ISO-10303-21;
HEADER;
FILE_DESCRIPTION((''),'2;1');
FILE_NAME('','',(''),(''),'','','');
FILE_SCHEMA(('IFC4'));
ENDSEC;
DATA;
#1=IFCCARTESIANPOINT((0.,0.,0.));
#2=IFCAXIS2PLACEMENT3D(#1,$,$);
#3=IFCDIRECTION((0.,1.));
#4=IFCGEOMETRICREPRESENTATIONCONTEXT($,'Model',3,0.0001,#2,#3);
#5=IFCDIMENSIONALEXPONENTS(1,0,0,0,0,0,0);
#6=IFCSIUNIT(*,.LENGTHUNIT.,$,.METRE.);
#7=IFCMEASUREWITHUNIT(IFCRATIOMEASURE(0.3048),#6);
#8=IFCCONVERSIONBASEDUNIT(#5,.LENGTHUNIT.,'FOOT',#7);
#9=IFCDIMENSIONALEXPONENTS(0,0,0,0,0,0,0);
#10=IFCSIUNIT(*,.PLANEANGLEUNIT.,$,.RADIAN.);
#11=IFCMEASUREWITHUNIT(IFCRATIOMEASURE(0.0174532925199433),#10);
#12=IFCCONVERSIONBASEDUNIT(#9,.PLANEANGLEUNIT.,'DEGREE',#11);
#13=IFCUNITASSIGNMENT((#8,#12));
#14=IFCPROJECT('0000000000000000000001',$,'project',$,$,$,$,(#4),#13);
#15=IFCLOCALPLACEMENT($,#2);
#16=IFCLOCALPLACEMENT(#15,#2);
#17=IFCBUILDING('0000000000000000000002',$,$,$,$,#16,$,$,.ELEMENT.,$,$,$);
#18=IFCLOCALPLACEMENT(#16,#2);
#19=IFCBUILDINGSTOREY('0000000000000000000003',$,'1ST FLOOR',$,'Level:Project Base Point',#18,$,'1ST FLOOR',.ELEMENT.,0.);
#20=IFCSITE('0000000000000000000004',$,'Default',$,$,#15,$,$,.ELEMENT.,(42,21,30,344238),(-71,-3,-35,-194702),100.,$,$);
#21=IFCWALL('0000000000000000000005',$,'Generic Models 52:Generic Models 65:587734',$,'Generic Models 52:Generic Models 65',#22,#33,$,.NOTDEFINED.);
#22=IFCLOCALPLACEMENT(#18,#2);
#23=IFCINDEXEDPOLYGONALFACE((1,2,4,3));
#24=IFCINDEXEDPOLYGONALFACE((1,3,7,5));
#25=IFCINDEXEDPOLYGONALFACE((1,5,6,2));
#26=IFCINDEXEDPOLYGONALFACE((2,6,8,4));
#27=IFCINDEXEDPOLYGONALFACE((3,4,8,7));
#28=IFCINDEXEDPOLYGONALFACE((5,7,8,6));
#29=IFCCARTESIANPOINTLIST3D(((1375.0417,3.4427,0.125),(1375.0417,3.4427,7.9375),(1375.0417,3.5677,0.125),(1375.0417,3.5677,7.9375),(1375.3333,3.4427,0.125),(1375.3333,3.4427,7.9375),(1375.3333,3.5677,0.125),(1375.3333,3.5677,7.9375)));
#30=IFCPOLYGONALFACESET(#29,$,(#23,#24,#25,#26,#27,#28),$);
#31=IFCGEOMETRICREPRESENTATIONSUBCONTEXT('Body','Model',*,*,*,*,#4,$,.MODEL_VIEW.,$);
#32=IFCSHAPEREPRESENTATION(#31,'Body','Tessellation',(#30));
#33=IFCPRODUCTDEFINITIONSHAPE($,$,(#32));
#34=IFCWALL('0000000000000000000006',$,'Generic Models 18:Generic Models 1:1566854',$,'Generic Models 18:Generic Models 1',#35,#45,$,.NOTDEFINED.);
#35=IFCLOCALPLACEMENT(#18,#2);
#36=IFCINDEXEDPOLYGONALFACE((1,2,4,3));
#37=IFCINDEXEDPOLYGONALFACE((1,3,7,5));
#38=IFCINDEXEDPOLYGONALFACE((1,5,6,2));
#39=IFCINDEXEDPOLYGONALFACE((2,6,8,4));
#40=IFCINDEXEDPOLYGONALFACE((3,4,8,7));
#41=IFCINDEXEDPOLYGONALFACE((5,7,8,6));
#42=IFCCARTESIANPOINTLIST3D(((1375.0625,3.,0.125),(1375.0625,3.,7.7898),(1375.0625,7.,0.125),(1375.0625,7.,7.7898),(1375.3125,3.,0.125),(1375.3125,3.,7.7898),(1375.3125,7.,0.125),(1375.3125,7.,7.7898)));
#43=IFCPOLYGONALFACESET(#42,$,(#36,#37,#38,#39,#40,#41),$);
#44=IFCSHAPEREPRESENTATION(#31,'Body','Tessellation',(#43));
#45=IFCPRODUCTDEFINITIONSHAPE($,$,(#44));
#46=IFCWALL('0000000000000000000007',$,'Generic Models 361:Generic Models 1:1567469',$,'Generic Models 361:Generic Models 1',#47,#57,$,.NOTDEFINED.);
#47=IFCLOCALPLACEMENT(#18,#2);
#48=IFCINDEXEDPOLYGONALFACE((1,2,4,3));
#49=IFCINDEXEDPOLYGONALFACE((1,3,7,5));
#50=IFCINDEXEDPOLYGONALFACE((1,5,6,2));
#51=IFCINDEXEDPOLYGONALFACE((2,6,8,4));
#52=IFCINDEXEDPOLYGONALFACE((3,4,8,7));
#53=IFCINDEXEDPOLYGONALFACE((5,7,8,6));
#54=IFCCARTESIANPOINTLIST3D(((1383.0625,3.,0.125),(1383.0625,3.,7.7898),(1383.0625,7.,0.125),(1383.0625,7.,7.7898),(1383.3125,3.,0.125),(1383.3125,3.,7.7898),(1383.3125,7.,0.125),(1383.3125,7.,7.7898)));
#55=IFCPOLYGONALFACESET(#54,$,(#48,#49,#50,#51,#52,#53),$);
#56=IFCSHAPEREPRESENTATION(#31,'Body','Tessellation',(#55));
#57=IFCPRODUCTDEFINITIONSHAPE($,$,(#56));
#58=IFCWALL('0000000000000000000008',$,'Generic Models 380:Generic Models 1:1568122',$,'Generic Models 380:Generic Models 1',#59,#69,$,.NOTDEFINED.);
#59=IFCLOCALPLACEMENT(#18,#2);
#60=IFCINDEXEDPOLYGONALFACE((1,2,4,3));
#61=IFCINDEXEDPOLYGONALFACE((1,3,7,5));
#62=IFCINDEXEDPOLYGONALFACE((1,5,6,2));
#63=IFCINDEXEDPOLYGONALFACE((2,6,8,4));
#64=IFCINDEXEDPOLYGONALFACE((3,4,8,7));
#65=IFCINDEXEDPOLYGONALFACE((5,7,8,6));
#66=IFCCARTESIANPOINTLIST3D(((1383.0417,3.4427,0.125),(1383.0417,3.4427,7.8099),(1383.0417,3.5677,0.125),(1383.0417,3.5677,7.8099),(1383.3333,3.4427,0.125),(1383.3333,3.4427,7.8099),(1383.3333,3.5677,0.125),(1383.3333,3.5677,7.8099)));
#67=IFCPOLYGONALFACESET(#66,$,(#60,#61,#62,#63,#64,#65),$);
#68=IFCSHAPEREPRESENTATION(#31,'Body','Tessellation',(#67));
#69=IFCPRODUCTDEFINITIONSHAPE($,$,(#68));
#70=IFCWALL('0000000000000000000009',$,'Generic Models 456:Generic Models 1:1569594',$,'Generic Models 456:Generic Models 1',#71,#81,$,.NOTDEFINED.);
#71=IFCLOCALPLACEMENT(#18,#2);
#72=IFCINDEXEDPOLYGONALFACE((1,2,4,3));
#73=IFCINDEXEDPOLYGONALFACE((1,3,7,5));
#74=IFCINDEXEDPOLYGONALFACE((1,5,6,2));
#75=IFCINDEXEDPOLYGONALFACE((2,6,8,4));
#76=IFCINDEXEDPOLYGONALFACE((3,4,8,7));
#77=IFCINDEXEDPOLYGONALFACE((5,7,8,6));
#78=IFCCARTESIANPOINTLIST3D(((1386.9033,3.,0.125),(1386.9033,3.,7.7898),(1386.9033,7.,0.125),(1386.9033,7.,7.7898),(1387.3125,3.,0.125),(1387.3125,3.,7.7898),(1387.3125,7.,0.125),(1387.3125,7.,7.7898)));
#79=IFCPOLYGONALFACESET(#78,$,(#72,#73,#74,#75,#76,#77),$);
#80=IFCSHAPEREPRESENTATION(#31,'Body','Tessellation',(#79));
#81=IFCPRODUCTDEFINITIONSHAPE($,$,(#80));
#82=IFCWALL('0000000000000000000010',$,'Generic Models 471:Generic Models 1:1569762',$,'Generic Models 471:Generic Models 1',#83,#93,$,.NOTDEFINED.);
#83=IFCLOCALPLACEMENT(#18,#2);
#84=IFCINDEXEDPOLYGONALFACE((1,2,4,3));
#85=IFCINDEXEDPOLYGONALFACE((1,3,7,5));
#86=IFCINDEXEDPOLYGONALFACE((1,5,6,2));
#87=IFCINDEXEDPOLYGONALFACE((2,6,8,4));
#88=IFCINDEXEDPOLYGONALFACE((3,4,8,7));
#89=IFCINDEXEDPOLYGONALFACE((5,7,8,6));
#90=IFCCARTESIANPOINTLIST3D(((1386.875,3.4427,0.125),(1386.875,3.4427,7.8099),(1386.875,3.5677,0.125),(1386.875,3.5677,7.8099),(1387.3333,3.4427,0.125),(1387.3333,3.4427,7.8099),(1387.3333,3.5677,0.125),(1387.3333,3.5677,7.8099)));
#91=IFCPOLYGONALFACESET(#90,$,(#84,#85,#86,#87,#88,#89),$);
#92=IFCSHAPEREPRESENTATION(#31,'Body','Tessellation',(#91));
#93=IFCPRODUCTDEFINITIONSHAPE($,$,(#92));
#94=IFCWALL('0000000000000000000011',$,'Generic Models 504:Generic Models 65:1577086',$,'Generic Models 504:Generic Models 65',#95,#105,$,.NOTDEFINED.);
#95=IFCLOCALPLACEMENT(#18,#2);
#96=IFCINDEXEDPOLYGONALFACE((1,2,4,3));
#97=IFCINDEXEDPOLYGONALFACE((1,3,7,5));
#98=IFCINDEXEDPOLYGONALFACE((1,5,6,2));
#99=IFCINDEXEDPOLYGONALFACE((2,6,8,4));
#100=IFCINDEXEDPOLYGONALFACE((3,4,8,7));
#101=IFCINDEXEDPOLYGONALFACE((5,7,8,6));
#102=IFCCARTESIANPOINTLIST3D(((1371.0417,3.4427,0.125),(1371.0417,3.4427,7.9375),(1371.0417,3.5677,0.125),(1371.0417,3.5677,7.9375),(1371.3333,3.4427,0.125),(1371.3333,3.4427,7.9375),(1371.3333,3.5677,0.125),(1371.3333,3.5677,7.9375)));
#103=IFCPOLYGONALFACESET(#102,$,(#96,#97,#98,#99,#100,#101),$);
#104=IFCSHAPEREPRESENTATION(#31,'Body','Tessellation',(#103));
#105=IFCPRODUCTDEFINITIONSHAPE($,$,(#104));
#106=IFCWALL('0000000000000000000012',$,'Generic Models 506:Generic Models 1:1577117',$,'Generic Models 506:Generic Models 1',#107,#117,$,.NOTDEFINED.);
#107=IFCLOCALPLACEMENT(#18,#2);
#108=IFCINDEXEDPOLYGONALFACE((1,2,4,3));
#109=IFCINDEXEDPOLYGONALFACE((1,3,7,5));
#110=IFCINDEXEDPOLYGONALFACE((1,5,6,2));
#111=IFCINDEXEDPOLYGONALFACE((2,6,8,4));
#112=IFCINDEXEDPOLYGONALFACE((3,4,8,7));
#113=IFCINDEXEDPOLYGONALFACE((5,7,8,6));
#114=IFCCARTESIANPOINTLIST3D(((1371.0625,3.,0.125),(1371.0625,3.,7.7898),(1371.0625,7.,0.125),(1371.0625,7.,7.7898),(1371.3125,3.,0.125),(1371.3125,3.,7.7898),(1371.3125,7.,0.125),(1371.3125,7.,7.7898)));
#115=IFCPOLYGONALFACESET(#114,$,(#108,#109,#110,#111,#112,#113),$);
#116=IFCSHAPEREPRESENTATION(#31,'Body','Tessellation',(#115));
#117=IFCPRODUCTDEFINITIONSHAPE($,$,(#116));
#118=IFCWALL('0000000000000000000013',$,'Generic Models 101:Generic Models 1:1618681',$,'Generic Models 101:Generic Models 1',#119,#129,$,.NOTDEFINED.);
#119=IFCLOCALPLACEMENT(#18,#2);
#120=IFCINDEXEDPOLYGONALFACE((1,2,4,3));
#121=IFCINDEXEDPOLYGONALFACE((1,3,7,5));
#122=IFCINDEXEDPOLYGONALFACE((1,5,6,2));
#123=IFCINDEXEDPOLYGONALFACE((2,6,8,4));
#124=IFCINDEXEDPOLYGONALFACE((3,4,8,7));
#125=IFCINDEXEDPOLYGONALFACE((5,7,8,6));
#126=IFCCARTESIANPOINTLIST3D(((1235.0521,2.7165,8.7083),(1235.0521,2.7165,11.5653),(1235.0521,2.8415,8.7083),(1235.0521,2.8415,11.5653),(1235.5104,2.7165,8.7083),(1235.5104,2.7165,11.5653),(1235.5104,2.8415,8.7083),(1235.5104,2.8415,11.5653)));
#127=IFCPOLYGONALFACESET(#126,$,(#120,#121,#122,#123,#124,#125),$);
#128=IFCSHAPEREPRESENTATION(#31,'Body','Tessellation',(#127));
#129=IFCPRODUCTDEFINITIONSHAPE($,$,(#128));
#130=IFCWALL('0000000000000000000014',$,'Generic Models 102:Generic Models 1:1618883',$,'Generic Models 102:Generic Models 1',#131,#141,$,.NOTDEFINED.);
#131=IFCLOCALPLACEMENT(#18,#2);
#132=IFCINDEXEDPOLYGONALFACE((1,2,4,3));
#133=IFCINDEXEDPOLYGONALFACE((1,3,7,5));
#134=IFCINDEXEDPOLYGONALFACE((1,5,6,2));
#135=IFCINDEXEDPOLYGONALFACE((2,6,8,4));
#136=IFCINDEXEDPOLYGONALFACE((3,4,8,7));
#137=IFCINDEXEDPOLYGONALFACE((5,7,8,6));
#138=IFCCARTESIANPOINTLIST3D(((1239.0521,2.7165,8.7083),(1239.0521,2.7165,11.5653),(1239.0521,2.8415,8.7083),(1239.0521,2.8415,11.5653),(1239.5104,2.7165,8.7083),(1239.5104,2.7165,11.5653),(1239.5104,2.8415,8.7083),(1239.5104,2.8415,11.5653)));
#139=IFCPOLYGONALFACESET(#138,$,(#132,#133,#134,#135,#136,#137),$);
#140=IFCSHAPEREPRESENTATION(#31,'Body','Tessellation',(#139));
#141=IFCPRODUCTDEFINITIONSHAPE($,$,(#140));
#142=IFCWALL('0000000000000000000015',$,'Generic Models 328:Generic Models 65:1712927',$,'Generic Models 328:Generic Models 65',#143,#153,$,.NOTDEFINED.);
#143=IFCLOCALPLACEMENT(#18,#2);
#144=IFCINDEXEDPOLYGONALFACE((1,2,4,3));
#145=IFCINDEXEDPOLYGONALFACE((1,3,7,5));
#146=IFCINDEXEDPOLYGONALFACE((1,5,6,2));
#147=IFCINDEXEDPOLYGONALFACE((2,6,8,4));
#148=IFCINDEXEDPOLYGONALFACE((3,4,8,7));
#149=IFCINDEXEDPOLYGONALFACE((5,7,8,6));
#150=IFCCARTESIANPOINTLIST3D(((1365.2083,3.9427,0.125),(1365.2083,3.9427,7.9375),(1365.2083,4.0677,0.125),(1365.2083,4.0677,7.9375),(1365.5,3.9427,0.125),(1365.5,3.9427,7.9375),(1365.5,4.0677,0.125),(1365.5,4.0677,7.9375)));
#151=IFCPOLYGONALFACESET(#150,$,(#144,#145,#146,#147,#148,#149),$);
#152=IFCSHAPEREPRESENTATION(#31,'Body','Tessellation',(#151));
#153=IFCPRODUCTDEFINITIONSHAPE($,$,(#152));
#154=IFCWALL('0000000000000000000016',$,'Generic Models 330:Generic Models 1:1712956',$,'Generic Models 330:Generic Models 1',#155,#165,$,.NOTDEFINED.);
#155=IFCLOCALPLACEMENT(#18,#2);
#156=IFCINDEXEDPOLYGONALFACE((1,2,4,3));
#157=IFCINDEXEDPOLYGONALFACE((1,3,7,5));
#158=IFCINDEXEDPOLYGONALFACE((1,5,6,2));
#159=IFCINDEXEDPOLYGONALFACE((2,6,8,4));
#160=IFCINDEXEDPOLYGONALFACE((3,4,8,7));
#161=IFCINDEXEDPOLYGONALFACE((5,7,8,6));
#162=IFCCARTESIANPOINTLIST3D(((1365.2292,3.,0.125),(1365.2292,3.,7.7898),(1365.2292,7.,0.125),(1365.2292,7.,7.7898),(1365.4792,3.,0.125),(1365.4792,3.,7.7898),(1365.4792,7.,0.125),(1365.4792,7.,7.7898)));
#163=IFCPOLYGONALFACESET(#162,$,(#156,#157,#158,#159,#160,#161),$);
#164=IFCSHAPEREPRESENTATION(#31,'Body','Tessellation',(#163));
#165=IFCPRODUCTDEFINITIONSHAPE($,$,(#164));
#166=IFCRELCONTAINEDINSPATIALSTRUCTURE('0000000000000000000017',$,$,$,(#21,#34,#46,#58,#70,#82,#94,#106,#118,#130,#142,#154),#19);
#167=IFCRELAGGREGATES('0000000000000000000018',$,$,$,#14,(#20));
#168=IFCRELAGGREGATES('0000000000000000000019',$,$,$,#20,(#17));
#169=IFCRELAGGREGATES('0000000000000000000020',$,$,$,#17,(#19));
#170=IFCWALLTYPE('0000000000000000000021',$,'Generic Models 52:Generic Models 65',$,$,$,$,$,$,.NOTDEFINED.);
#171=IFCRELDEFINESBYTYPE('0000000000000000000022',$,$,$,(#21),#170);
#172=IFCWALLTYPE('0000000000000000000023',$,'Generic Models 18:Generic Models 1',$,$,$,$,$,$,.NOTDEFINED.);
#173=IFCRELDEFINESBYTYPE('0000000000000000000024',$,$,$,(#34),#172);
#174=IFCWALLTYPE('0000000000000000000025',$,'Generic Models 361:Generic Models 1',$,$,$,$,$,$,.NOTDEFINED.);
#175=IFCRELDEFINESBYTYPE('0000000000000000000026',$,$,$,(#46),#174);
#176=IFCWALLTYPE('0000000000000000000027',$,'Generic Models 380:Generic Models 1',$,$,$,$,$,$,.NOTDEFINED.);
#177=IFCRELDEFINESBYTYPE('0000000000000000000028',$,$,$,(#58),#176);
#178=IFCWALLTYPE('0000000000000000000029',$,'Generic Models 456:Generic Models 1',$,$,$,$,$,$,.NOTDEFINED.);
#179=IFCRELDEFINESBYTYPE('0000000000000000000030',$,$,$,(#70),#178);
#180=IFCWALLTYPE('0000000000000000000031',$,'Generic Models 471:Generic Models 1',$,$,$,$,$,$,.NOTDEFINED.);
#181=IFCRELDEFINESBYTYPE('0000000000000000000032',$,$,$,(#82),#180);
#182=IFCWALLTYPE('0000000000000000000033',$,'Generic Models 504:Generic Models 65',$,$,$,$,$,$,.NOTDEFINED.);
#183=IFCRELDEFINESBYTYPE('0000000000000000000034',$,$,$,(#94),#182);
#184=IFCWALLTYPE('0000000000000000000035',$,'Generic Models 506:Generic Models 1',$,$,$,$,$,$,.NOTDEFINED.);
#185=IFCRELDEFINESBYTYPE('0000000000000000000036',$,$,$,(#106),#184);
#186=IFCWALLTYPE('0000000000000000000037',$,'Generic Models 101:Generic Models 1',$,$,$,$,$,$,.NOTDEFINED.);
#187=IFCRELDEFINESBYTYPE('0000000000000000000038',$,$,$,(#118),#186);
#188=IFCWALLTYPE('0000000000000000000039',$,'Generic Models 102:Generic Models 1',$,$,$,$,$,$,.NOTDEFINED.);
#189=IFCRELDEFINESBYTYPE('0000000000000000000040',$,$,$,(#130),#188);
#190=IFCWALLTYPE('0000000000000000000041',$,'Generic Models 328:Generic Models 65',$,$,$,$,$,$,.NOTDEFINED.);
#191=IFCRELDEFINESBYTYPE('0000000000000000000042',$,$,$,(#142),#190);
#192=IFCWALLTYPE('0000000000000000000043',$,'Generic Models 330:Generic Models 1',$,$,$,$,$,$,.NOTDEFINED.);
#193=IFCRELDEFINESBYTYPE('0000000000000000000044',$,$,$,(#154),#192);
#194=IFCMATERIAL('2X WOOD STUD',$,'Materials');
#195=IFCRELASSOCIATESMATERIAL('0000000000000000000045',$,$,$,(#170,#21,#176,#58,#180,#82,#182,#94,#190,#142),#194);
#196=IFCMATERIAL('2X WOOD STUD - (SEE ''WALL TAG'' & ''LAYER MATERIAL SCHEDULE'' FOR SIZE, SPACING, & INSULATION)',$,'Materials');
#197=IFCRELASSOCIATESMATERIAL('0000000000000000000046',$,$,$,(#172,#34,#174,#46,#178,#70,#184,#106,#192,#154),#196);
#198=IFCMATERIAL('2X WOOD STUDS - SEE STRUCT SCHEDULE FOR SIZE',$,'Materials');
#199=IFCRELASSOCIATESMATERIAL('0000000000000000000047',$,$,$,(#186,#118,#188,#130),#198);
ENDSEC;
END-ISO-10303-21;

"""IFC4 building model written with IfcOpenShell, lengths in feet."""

from ifc_helpers import new_model, entity, si_unit, converted_unit, direction, frame, frame_2d, origin, place, context, subcontext, project, spatial, rectangle, extrude, material, type_object, element, save


model = new_model("IFC4")

# Units and contexts
model_context = context("Model", 3, precision=0.0001, world=origin(), true_north=direction((0.0, 1.0)))
body_context = subcontext(model_context, "Body", "Model", "MODEL_VIEW")
ifc_project = project(units=[converted_unit("LENGTHUNIT", "FOOT", entity("IfcRatioMeasure", 0.3048), si_unit("LENGTHUNIT", "METRE"), dimensions=[1, 0, 0, 0, 0, 0, 0]), converted_unit("PLANEANGLEUNIT", "DEGREE", entity("IfcRatioMeasure", 0.0174532925199433), si_unit("PLANEANGLEUNIT", "RADIAN"), dimensions=[0, 0, 0, 0, 0, 0, 0])], contexts=[model_context])

# Site, building, storey
site_placement = place(None, origin())
site = spatial("IfcSite", under=ifc_project, at=site_placement, Name="Default", CompositionType="ELEMENT", RefLatitude=(42, 21, 30, 344238), RefLongitude=(-71, -3, -35, -194702), RefElevation=100.0)
building_placement = place(site_placement, origin())
building = spatial("IfcBuilding", under=site, at=building_placement, CompositionType="ELEMENT")
storey_placement = place(building_placement, origin())
storey = spatial("IfcBuildingStorey", under=building, at=storey_placement, Name="1ST FLOOR", ObjectType="Level:Project Base Point", LongName="1ST FLOOR", CompositionType="ELEMENT", Elevation=0.0)

# Walls
ifc_material_1 = material(Name="2X WOOD STUD", Category="Materials")
wall_type_1 = type_object("IfcWallType", Name="Generic Models 52:Generic Models 65", PredefinedType="NOTDEFINED", material=ifc_material_1)
wall_1_placement = place(storey_placement, frame((1375.0417, 3.4427, 0.125)))
element("IfcWall", 1, at=wall_1_placement, inside=storey, type_object=wall_type_1, material=ifc_material_1, Name="Generic Models 52:Generic Models 65:587734", ObjectType="Generic Models 52:Generic Models 65", PredefinedType="NOTDEFINED", context=body_context, shape_type="SweptSolid", body=[
    extrude(rectangle(XDim=0.125, YDim=0.2917, at=frame_2d((0.0, 0.0), x_axis=(1.0, 0.0))), frame((0.1458, 0.0625, 0.0), z_axis=(0.0, 0.0, 1.0), x_axis=(0.0, 1.0, 0.0)), (0.0, 0.0, 1.0), 7.8125),
])
ifc_material_2 = material(Name="2X WOOD STUD - (SEE 'WALL TAG' & 'LAYER MATERIAL SCHEDULE' FOR SIZE, SPACING, & INSULATION)", Category="Materials")
wall_type_2 = type_object("IfcWallType", Name="Generic Models 18:Generic Models 1", PredefinedType="NOTDEFINED", material=ifc_material_2)
wall_2_placement = place(storey_placement, frame((1375.0625, 3.0, 0.125), z_axis=(0.0, 0.0, 1.0), x_axis=(0.0, 1.0, 0.0)))
element("IfcWall", 2, at=wall_2_placement, inside=storey, type_object=wall_type_2, material=ifc_material_2, Name="Generic Models 18:Generic Models 1:1566854", ObjectType="Generic Models 18:Generic Models 1", PredefinedType="NOTDEFINED", context=body_context, shape_type="SweptSolid", body=[
    extrude(rectangle(XDim=4.0, YDim=0.25, at=frame_2d((0.0, 0.0), x_axis=(1.0, 0.0))), frame((2.0, -0.125, 0.0)), (0.0, 0.0, 1.0), 7.6648),
])
wall_type_3 = type_object("IfcWallType", Name="Generic Models 361:Generic Models 1", PredefinedType="NOTDEFINED", material=ifc_material_2)
wall_3_placement = place(storey_placement, frame((1383.0625, 3.0, 0.125), z_axis=(0.0, 0.0, 1.0), x_axis=(0.0, 1.0, 0.0)))
element("IfcWall", 3, at=wall_3_placement, inside=storey, type_object=wall_type_3, material=ifc_material_2, Name="Generic Models 361:Generic Models 1:1567469", ObjectType="Generic Models 361:Generic Models 1", PredefinedType="NOTDEFINED", context=body_context, shape_type="SweptSolid", body=[
    extrude(rectangle(XDim=4.0, YDim=0.25, at=frame_2d((0.0, 0.0), x_axis=(1.0, 0.0))), frame((2.0, -0.125, 0.0)), (0.0, 0.0, 1.0), 7.6648),
])
wall_type_4 = type_object("IfcWallType", Name="Generic Models 380:Generic Models 1", PredefinedType="NOTDEFINED", material=ifc_material_1)
wall_4_placement = place(storey_placement, frame((1383.0417, 3.4427, 0.125)))
element("IfcWall", 4, at=wall_4_placement, inside=storey, type_object=wall_type_4, material=ifc_material_1, Name="Generic Models 380:Generic Models 1:1568122", ObjectType="Generic Models 380:Generic Models 1", PredefinedType="NOTDEFINED", context=body_context, shape_type="SweptSolid", body=[
    extrude(rectangle(XDim=0.125, YDim=0.2917, at=frame_2d((0.0, 0.0), x_axis=(1.0, 0.0))), frame((0.1458, 0.0625, 0.0), z_axis=(0.0, 0.0, 1.0), x_axis=(0.0, 1.0, 0.0)), (0.0, 0.0, 1.0), 7.6849),
])
wall_type_5 = type_object("IfcWallType", Name="Generic Models 456:Generic Models 1", PredefinedType="NOTDEFINED", material=ifc_material_2)
wall_5_placement = place(storey_placement, frame((1386.9033, 3.0, 0.125), z_axis=(0.0, 0.0, 1.0), x_axis=(0.0, 1.0, 0.0)))
element("IfcWall", 5, at=wall_5_placement, inside=storey, type_object=wall_type_5, material=ifc_material_2, Name="Generic Models 456:Generic Models 1:1569594", ObjectType="Generic Models 456:Generic Models 1", PredefinedType="NOTDEFINED", context=body_context, shape_type="SweptSolid", body=[
    extrude(rectangle(XDim=4.0, YDim=0.4092, at=frame_2d((0.0, 0.0), x_axis=(1.0, 0.0))), frame((2.0, -0.2046, 0.0)), (0.0, 0.0, 1.0), 7.6648),
])
wall_type_6 = type_object("IfcWallType", Name="Generic Models 471:Generic Models 1", PredefinedType="NOTDEFINED", material=ifc_material_1)
wall_6_placement = place(storey_placement, frame((1386.875, 3.4427, 0.125)))
element("IfcWall", 6, at=wall_6_placement, inside=storey, type_object=wall_type_6, material=ifc_material_1, Name="Generic Models 471:Generic Models 1:1569762", ObjectType="Generic Models 471:Generic Models 1", PredefinedType="NOTDEFINED", context=body_context, shape_type="SweptSolid", body=[
    extrude(rectangle(XDim=0.125, YDim=0.4583, at=frame_2d((0.0, 0.0), x_axis=(1.0, 0.0))), frame((0.2292, 0.0625, 0.0), z_axis=(0.0, 0.0, 1.0), x_axis=(0.0, 1.0, 0.0)), (0.0, 0.0, 1.0), 7.6849),
])
wall_type_7 = type_object("IfcWallType", Name="Generic Models 504:Generic Models 65", PredefinedType="NOTDEFINED", material=ifc_material_1)
wall_7_placement = place(storey_placement, frame((1371.0417, 3.4427, 0.125)))
element("IfcWall", 7, at=wall_7_placement, inside=storey, type_object=wall_type_7, material=ifc_material_1, Name="Generic Models 504:Generic Models 65:1577086", ObjectType="Generic Models 504:Generic Models 65", PredefinedType="NOTDEFINED", context=body_context, shape_type="SweptSolid", body=[
    extrude(rectangle(XDim=0.125, YDim=0.2917, at=frame_2d((0.0, 0.0), x_axis=(1.0, 0.0))), frame((0.1458, 0.0625, 0.0), z_axis=(0.0, 0.0, 1.0), x_axis=(0.0, 1.0, 0.0)), (0.0, 0.0, 1.0), 7.8125),
])
wall_type_8 = type_object("IfcWallType", Name="Generic Models 506:Generic Models 1", PredefinedType="NOTDEFINED", material=ifc_material_2)
wall_8_placement = place(storey_placement, frame((1371.0625, 3.0, 0.125), z_axis=(0.0, 0.0, 1.0), x_axis=(0.0, 1.0, 0.0)))
element("IfcWall", 8, at=wall_8_placement, inside=storey, type_object=wall_type_8, material=ifc_material_2, Name="Generic Models 506:Generic Models 1:1577117", ObjectType="Generic Models 506:Generic Models 1", PredefinedType="NOTDEFINED", context=body_context, shape_type="SweptSolid", body=[
    extrude(rectangle(XDim=4.0, YDim=0.25, at=frame_2d((0.0, 0.0), x_axis=(1.0, 0.0))), frame((2.0, -0.125, 0.0)), (0.0, 0.0, 1.0), 7.6648),
])
ifc_material_3 = material(Name="2X WOOD STUDS - SEE STRUCT SCHEDULE FOR SIZE", Category="Materials")
wall_type_9 = type_object("IfcWallType", Name="Generic Models 101:Generic Models 1", PredefinedType="NOTDEFINED", material=ifc_material_3)
wall_9_placement = place(storey_placement, frame((1235.0521, 2.7165, 8.7083)))
element("IfcWall", 9, at=wall_9_placement, inside=storey, type_object=wall_type_9, material=ifc_material_3, Name="Generic Models 101:Generic Models 1:1618681", ObjectType="Generic Models 101:Generic Models 1", PredefinedType="NOTDEFINED", context=body_context, shape_type="SweptSolid", body=[
    extrude(rectangle(XDim=0.125, YDim=0.4583, at=frame_2d((0.0, 0.0), x_axis=(1.0, 0.0))), frame((0.2292, 0.0625, 0.0), z_axis=(0.0, 0.0, 1.0), x_axis=(0.0, 1.0, 0.0)), (0.0, 0.0, 1.0), 2.857),
])
wall_type_10 = type_object("IfcWallType", Name="Generic Models 102:Generic Models 1", PredefinedType="NOTDEFINED", material=ifc_material_3)
wall_10_placement = place(storey_placement, frame((1239.0521, 2.7165, 8.7083)))
element("IfcWall", 10, at=wall_10_placement, inside=storey, type_object=wall_type_10, material=ifc_material_3, Name="Generic Models 102:Generic Models 1:1618883", ObjectType="Generic Models 102:Generic Models 1", PredefinedType="NOTDEFINED", context=body_context, shape_type="SweptSolid", body=[
    extrude(rectangle(XDim=0.125, YDim=0.4583, at=frame_2d((0.0, 0.0), x_axis=(1.0, 0.0))), frame((0.2292, 0.0625, 0.0), z_axis=(0.0, 0.0, 1.0), x_axis=(0.0, 1.0, 0.0)), (0.0, 0.0, 1.0), 2.857),
])
wall_type_11 = type_object("IfcWallType", Name="Generic Models 328:Generic Models 65", PredefinedType="NOTDEFINED", material=ifc_material_1)
wall_11_placement = place(storey_placement, frame((1365.2083, 3.9427, 0.125)))
element("IfcWall", 11, at=wall_11_placement, inside=storey, type_object=wall_type_11, material=ifc_material_1, Name="Generic Models 328:Generic Models 65:1712927", ObjectType="Generic Models 328:Generic Models 65", PredefinedType="NOTDEFINED", context=body_context, shape_type="SweptSolid", body=[
    extrude(rectangle(XDim=0.125, YDim=0.2917, at=frame_2d((0.0, 0.0), x_axis=(1.0, 0.0))), frame((0.1458, 0.0625, 0.0), z_axis=(0.0, 0.0, 1.0), x_axis=(0.0, 1.0, 0.0)), (0.0, 0.0, 1.0), 7.8125),
])
wall_type_12 = type_object("IfcWallType", Name="Generic Models 330:Generic Models 1", PredefinedType="NOTDEFINED", material=ifc_material_2)
wall_12_placement = place(storey_placement, frame((1365.2292, 3.0, 0.125), z_axis=(0.0, 0.0, 1.0), x_axis=(0.0, 1.0, 0.0)))
element("IfcWall", 12, at=wall_12_placement, inside=storey, type_object=wall_type_12, material=ifc_material_2, Name="Generic Models 330:Generic Models 1:1712956", ObjectType="Generic Models 330:Generic Models 1", PredefinedType="NOTDEFINED", context=body_context, shape_type="SweptSolid", body=[
    extrude(rectangle(XDim=4.0, YDim=0.25, at=frame_2d((0.0, 0.0), x_axis=(1.0, 0.0))), frame((2.0, -0.125, 0.0)), (0.0, 0.0, 1.0), 7.6648),
])

save(model, "model.ifc")
